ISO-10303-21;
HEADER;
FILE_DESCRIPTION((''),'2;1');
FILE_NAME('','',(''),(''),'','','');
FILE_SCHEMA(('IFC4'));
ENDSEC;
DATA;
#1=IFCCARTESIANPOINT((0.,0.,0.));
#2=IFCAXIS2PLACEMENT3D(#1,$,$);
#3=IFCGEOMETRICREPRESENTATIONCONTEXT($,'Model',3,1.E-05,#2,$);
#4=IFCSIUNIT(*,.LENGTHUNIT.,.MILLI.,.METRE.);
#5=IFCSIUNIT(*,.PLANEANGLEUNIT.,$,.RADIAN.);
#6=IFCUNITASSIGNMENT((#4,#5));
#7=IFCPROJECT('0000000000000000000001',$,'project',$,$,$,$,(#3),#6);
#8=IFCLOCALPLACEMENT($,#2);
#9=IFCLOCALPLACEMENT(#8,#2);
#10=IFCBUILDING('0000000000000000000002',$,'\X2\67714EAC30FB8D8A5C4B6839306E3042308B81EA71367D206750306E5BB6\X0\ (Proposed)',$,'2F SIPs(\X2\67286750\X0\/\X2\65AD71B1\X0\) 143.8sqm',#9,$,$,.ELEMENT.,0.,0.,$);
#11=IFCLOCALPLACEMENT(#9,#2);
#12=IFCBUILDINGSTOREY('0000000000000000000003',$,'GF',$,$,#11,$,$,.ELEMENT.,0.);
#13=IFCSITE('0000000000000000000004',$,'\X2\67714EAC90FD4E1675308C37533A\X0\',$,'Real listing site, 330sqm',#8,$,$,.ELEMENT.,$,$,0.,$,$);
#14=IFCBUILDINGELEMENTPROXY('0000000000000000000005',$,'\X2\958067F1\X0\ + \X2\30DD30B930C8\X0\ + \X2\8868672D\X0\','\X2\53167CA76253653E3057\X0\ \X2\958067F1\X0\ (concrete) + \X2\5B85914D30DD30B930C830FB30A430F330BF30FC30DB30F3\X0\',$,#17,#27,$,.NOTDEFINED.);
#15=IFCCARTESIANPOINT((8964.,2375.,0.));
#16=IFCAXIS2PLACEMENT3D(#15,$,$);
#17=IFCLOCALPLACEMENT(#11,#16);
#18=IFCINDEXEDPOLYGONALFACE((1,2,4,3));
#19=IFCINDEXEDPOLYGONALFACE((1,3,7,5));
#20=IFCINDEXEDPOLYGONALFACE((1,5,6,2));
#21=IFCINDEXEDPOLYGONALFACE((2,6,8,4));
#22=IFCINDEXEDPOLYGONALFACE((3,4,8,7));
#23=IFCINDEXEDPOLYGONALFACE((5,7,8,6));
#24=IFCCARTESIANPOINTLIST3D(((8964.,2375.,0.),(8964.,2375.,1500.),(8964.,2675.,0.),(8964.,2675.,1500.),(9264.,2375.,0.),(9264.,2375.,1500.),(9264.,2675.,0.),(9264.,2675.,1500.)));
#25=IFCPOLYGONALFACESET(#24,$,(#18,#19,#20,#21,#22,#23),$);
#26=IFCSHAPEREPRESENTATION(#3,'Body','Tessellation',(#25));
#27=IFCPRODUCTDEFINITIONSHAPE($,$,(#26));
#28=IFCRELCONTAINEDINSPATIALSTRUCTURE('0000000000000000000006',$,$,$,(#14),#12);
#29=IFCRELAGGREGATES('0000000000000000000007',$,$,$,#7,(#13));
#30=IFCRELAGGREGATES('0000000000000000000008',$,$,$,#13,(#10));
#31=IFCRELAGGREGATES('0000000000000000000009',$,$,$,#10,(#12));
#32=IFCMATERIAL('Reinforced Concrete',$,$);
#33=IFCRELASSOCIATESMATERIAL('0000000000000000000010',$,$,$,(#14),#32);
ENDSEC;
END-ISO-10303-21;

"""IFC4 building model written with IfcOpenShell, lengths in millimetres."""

from ifc_helpers import new_model, si_unit, frame, frame_2d, origin, place, context, project, spatial, rectangle, extrude, material, element, save


model = new_model("IFC4")

# Units and contexts
model_context = context("Model", 3, precision=1e-05, world=origin())
ifc_project = project(units=[si_unit("LENGTHUNIT", "METRE", prefix="MILLI"), si_unit("PLANEANGLEUNIT", "RADIAN")], contexts=[model_context])

# Site, building, storey
site_placement = place(None, origin())
site = spatial("IfcSite", under=ifc_project, at=site_placement, Name="東京都世田谷区", ObjectType="Real listing site, 330sqm", CompositionType="ELEMENT", RefElevation=0.0)
building_placement = place(site_placement, origin())
building = spatial("IfcBuilding", under=site, at=building_placement, Name="東京・越屋根のある自然素材の家 (Proposed)", ObjectType="2F SIPs(木材/断熱) 143.8sqm", CompositionType="ELEMENT", ElevationOfRefHeight=0.0, ElevationOfTerrain=0.0)
storey_placement = place(building_placement, origin())
storey = spatial("IfcBuildingStorey", under=building, at=storey_placement, Name="GF", CompositionType="ELEMENT", Elevation=0.0)

# Shared definitions
ifc_material_1 = material(Name="Reinforced Concrete")

# Building element proxy
proxy_placement = place(storey_placement, frame((8964.0, 2375.0, 0.0)))
element("IfcBuildingElementProxy", 1, at=proxy_placement, inside=storey, material=ifc_material_1, Name="門柱 + ポスト + 表札", Description="化粧打放し 門柱 (concrete) + 宅配ポスト・インターホン", PredefinedType="NOTDEFINED", context=model_context, shape_type="SweptSolid", body=[
    extrude(rectangle(XDim=300.0, YDim=300.0, at=frame_2d((150.0, 150.0))), frame((8964.0, 2375.0, 0.0)), (0.0, 0.0, 1.0), 1500.0),
])

save(model, "model.ifc")
